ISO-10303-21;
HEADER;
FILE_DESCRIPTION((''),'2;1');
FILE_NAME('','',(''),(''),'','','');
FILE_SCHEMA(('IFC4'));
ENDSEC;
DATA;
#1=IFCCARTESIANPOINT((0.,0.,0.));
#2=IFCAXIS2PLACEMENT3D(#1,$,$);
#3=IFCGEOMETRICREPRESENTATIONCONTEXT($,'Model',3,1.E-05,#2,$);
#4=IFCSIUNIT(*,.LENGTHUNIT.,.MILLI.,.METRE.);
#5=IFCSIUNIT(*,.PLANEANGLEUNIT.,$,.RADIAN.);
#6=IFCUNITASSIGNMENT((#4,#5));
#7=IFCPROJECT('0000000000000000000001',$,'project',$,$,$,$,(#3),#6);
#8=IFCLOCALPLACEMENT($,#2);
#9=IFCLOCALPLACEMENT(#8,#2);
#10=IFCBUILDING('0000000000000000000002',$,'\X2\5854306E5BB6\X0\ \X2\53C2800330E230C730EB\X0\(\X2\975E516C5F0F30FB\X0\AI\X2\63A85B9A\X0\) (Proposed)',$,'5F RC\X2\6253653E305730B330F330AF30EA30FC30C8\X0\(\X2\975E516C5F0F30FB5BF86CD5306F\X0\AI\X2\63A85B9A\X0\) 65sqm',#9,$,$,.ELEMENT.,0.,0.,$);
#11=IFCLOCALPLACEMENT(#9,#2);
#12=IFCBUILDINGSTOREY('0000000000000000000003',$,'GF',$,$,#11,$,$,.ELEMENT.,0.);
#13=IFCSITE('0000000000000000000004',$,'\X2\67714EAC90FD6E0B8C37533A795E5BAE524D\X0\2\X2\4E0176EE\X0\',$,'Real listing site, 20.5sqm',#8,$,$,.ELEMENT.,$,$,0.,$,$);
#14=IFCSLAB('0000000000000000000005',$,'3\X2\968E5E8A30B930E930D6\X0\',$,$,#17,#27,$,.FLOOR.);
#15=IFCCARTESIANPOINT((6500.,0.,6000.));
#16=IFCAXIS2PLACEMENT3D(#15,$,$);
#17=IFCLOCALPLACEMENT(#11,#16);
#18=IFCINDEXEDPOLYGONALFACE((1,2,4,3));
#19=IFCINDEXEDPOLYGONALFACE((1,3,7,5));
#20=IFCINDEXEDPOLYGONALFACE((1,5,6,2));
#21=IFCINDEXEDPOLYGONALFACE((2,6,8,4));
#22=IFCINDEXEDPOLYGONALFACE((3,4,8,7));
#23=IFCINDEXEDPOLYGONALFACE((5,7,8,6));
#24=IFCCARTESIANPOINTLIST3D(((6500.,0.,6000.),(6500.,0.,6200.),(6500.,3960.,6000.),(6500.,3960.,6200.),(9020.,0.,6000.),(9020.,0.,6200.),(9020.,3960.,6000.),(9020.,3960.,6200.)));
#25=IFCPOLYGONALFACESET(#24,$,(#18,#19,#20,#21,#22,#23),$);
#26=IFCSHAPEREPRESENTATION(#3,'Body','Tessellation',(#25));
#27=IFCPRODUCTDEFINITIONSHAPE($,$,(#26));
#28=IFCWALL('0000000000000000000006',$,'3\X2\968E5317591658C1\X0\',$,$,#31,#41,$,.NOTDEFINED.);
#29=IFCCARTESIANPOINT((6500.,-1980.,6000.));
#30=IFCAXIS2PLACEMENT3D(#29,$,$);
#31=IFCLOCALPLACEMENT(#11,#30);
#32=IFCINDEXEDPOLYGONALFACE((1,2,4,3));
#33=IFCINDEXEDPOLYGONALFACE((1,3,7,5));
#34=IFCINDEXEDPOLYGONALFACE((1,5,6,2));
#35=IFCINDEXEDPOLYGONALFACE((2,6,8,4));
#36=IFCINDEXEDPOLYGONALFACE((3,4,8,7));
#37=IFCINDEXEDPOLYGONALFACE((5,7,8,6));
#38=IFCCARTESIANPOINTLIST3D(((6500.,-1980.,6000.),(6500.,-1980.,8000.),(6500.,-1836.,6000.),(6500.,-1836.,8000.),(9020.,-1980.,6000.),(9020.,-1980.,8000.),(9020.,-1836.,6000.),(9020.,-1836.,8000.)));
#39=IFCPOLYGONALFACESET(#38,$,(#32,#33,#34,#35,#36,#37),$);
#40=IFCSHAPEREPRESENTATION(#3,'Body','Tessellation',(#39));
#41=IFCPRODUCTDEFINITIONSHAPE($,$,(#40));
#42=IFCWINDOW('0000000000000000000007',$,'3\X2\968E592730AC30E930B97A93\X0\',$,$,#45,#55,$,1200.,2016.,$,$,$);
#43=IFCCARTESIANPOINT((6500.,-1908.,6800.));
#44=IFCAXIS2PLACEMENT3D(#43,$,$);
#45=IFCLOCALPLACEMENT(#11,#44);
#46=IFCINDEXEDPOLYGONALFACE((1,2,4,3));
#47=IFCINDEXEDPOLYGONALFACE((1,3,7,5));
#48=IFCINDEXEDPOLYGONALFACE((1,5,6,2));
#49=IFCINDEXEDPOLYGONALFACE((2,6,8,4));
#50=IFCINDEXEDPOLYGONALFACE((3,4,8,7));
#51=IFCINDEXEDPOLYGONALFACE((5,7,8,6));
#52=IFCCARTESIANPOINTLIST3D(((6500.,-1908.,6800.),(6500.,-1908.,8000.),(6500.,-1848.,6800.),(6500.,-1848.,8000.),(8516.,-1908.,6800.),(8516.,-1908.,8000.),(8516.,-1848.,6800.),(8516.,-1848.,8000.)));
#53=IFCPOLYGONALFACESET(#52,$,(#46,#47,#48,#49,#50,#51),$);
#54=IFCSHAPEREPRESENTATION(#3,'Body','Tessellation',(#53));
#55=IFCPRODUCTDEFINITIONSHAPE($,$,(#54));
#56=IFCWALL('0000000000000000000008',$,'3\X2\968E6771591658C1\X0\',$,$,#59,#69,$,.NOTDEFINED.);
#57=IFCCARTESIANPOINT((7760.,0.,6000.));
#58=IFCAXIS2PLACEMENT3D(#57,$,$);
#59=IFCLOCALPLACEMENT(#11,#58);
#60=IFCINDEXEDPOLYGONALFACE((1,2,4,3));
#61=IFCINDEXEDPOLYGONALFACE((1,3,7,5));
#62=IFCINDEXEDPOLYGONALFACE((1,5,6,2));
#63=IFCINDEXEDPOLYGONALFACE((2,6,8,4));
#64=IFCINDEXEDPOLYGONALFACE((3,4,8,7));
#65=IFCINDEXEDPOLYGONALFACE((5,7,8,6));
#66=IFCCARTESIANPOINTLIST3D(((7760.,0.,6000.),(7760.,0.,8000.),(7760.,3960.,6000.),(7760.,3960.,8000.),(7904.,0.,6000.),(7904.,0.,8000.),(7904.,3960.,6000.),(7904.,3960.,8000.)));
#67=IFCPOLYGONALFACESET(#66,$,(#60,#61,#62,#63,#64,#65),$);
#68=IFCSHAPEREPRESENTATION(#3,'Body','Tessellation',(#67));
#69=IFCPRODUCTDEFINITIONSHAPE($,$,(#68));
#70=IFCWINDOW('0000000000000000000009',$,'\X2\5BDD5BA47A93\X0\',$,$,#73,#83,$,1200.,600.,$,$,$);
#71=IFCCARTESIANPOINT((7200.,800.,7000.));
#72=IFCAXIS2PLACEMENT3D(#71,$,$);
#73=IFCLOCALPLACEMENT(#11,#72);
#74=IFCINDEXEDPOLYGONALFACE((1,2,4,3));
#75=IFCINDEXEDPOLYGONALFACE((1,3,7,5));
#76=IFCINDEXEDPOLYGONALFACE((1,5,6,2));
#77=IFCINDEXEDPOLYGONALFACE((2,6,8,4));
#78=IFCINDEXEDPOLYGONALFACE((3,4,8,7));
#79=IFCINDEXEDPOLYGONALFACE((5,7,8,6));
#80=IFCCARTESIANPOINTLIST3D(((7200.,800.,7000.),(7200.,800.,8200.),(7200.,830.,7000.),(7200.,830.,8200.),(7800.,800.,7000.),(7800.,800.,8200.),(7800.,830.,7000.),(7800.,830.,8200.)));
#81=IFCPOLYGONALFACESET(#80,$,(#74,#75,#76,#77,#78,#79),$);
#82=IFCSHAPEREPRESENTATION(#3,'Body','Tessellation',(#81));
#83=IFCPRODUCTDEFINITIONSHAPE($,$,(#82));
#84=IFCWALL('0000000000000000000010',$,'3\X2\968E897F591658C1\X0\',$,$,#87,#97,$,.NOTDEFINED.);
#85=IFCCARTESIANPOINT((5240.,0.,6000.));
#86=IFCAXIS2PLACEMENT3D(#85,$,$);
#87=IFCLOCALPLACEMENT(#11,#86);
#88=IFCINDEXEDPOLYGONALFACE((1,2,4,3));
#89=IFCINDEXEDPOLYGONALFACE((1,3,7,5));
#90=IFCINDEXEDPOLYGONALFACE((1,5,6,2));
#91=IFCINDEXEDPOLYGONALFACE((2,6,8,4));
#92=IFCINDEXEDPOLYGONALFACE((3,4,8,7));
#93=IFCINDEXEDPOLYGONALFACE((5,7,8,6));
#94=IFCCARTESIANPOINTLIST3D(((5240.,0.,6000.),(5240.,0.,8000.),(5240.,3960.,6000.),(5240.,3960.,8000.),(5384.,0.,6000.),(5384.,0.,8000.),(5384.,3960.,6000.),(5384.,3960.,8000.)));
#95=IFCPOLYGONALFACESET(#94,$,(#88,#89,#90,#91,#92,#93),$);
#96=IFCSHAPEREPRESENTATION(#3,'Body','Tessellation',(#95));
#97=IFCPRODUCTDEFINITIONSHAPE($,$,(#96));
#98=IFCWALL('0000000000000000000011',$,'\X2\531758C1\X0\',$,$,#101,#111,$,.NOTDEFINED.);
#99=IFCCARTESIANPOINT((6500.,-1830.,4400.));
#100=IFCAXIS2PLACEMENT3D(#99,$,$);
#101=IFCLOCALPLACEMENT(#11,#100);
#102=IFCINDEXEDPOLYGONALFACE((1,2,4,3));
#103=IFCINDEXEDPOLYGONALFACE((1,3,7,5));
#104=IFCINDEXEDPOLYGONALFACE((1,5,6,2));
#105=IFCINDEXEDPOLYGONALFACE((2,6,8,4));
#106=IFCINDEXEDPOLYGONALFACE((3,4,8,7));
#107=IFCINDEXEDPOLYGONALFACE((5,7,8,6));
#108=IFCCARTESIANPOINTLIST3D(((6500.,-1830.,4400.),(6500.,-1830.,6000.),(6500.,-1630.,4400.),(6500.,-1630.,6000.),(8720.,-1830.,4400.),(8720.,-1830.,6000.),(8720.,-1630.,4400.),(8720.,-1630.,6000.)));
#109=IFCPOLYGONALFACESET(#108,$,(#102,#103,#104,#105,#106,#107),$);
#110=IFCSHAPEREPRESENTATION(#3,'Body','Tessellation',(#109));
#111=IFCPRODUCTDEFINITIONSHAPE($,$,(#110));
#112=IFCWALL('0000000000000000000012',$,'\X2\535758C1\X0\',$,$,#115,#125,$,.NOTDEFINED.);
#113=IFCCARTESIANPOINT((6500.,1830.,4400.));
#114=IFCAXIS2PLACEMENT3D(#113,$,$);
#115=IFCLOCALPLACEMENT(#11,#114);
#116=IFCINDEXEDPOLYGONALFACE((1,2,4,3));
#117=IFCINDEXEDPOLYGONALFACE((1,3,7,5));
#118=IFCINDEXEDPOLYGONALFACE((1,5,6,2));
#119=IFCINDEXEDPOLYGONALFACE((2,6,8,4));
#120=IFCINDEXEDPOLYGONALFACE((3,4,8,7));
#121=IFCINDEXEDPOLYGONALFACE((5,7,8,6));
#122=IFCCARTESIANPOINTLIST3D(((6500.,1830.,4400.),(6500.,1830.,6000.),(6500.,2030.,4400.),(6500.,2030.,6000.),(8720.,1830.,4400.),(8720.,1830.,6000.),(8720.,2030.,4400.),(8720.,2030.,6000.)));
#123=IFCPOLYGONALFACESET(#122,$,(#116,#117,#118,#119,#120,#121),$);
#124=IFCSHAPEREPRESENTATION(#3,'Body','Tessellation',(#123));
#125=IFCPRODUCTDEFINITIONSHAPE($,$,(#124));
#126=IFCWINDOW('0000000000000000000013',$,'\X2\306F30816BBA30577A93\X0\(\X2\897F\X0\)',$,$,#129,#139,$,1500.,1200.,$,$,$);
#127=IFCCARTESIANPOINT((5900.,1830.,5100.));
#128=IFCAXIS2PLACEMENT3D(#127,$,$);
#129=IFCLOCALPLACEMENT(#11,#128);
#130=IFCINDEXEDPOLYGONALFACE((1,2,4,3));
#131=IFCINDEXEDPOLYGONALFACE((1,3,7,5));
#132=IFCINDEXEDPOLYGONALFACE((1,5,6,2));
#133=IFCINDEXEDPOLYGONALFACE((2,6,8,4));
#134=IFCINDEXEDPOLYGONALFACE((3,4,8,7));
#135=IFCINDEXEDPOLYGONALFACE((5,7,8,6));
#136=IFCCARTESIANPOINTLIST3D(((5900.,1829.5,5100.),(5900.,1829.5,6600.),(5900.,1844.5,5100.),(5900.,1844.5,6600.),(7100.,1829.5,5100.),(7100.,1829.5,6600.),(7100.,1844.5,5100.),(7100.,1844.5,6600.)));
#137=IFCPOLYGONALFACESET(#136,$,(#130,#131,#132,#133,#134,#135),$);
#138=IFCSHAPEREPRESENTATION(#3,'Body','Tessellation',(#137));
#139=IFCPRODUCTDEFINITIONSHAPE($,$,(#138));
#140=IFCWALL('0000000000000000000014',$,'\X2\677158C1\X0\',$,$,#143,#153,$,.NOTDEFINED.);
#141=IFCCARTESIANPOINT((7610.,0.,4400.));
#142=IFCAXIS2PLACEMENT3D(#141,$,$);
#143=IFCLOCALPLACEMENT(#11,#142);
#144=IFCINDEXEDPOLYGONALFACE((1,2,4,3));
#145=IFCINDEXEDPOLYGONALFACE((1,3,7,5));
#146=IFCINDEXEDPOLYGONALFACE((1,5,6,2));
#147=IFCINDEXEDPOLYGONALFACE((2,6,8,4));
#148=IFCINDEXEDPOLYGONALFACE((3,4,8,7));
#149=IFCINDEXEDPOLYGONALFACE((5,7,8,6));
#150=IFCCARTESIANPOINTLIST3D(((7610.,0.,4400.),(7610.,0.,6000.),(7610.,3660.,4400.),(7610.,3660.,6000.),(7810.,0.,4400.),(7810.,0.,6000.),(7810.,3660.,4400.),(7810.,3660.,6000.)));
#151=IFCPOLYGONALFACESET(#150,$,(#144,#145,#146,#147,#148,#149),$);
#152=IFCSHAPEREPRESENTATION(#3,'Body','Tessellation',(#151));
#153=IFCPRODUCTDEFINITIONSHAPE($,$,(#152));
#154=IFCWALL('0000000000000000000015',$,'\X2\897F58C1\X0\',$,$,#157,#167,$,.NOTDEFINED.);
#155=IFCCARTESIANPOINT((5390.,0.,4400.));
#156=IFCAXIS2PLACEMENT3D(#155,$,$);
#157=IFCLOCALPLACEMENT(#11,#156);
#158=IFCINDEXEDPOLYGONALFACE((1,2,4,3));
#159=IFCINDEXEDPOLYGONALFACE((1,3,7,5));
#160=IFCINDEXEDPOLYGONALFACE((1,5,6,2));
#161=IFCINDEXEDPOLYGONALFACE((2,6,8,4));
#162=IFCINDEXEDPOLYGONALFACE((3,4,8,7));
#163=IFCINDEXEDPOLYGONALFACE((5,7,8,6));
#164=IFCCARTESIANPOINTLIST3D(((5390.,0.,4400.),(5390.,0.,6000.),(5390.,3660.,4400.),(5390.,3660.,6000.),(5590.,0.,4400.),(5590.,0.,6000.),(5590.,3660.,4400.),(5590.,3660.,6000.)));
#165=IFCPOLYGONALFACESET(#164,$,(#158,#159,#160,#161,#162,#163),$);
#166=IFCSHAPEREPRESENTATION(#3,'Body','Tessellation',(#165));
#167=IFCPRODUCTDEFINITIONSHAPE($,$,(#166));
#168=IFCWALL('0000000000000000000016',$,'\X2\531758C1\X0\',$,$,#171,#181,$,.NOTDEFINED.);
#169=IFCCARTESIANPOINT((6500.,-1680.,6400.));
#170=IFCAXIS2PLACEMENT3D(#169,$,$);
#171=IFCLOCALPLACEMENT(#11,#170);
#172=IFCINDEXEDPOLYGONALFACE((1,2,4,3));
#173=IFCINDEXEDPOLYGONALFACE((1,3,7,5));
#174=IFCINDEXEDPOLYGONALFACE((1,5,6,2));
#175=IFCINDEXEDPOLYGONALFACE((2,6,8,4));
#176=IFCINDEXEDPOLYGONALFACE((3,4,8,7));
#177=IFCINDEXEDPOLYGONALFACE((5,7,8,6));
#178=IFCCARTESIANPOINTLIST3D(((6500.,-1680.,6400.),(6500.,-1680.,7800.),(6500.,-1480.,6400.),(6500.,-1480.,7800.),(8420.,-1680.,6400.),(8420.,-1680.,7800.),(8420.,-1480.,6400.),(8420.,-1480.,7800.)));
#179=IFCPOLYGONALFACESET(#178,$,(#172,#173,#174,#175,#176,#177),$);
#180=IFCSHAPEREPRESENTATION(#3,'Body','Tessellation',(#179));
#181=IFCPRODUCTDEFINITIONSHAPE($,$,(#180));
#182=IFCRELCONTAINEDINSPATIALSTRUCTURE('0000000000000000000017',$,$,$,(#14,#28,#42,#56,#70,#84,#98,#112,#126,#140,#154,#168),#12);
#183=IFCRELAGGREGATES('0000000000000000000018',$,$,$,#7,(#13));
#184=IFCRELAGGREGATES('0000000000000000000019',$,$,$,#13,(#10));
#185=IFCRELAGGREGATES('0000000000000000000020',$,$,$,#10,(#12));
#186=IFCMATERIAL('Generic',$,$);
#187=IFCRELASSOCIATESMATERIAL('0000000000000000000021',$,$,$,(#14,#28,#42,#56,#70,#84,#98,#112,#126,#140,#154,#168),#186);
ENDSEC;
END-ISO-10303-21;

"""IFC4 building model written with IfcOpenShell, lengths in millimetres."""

from ifc_helpers import new_model, si_unit, frame, frame_2d, origin, place, context, project, spatial, rectangle, extrude, material, element, fill, save


model = new_model("IFC4")

# Units and contexts
model_context = context("Model", 3, precision=1e-05, world=origin())
ifc_project = project(units=[si_unit("LENGTHUNIT", "METRE", prefix="MILLI"), si_unit("PLANEANGLEUNIT", "RADIAN")], contexts=[model_context])

# Site, building, storey
site_placement = place(None, origin())
site = spatial("IfcSite", under=ifc_project, at=site_placement, Name="東京都渋谷区神宮前2丁目", ObjectType="Real listing site, 20.5sqm", CompositionType="ELEMENT", RefElevation=0.0)
building_placement = place(site_placement, origin())
building = spatial("IfcBuilding", under=site, at=building_placement, Name="塔の家 参考モデル(非公式・AI推定) (Proposed)", ObjectType="5F RC打放しコンクリート(非公式・寸法はAI推定) 65sqm", CompositionType="ELEMENT", ElevationOfRefHeight=0.0, ElevationOfTerrain=0.0)
storey_placement = place(building_placement, origin())
storey = spatial("IfcBuildingStorey", under=building, at=storey_placement, Name="GF", CompositionType="ELEMENT", Elevation=0.0)

# Slab
ifc_material = material(Name="Generic")
slab_placement = place(storey_placement, frame((6500.0, 0.0, 6000.0)))
element("IfcSlab", 1, at=slab_placement, inside=storey, material=ifc_material, Name="3階床スラブ", PredefinedType="FLOOR", context=model_context, shape_type="SweptSolid", body=[
    extrude(rectangle(XDim=2520.0, YDim=3960.0, at=frame_2d((1260.0, 1980.0))), frame((6500.0, 0.0, 6000.0)), (0.0, 0.0, 1.0), 200.0),
])

# Walls, openings, windows
wall_1_placement = place(storey_placement, frame((6500.0, -1980.0, 6000.0)))
wall_1 = element("IfcWall", 2, at=wall_1_placement, inside=storey, material=ifc_material, Name="3階北外壁", PredefinedType="NOTDEFINED", context=model_context, shape_type="SweptSolid", body=[
    extrude(rectangle(XDim=2520.0, YDim=144.0, at=frame_2d((1260.0, 72.0))), frame((6500.0, -1980.0, 6000.0)), (0.0, 0.0, 1.0), 2000.0),
])
opening_1_placement = place(storey_placement, frame((6500.0, -1908.0, 6800.0)))
opening_1 = element("IfcOpeningElement", 3, at=opening_1_placement, cuts=wall_1, PredefinedType="NOTDEFINED", context=model_context, shape_type="SweptSolid", body=[
    extrude(rectangle(XDim=2016.0, YDim=60.0, at=frame_2d((1008.0, 30.0))), frame((6500.0, -1908.0, 6800.0)), (0.0, 0.0, 1.0), 1200.0),
])
window_1_placement = place(storey_placement, frame((6500.0, -1908.0, 6800.0)))
window_1 = element("IfcWindow", 4, at=window_1_placement, inside=storey, material=ifc_material, Name="3階大ガラス窓", OverallHeight=1200.0, OverallWidth=2016.0, context=model_context, shape_type="SweptSolid", body=[
    extrude(rectangle(XDim=2016.0, YDim=60.0, at=frame_2d((1008.0, 30.0))), frame((6500.0, -1908.0, 6800.0)), (0.0, 0.0, 1.0), 1200.0),
])
fill(opening_1, window_1)
wall_2_placement = place(storey_placement, frame((7760.0, 0.0, 6000.0)))
wall_2 = element("IfcWall", 5, at=wall_2_placement, inside=storey, material=ifc_material, Name="3階東外壁", PredefinedType="NOTDEFINED", context=model_context, shape_type="SweptSolid", body=[
    extrude(rectangle(XDim=144.0, YDim=3960.0, at=frame_2d((72.0, 1980.0))), frame((7760.0, 0.0, 6000.0)), (0.0, 0.0, 1.0), 2000.0),
])
opening_2_placement = place(storey_placement, frame((7200.0, 800.0, 7000.0)))
opening_2 = element("IfcOpeningElement", 6, at=opening_2_placement, cuts=wall_2, PredefinedType="NOTDEFINED", context=model_context, shape_type="SweptSolid", body=[
    extrude(rectangle(XDim=600.0, YDim=30.0, at=frame_2d((300.0, 15.0))), frame((7200.0, 800.0, 7000.0)), (0.0, 0.0, 1.0), 1200.0),
])
window_2_placement = place(storey_placement, frame((7200.0, 800.0, 7000.0)))
window_2 = element("IfcWindow", 7, at=window_2_placement, inside=storey, material=ifc_material, Name="寝室窓", OverallHeight=1200.0, OverallWidth=600.0, context=model_context, shape_type="SweptSolid", body=[
    extrude(rectangle(XDim=600.0, YDim=30.0, at=frame_2d((300.0, 15.0))), frame((7200.0, 800.0, 7000.0)), (0.0, 0.0, 1.0), 1200.0),
])
fill(opening_2, window_2)

# Walls
wall_3_placement = place(storey_placement, frame((5240.0, 0.0, 6000.0)))
element("IfcWall", 8, at=wall_3_placement, inside=storey, material=ifc_material, Name="3階西外壁", PredefinedType="NOTDEFINED", context=model_context, shape_type="SweptSolid", body=[
    extrude(rectangle(XDim=144.0, YDim=3960.0, at=frame_2d((72.0, 1980.0))), frame((5240.0, 0.0, 6000.0)), (0.0, 0.0, 1.0), 2000.0),
])
wall_4_placement = place(storey_placement, frame((6500.0, -1830.0, 4400.0)))
element("IfcWall", 9, at=wall_4_placement, inside=storey, material=ifc_material, Name="北壁", PredefinedType="NOTDEFINED", context=model_context, shape_type="SweptSolid", body=[
    extrude(rectangle(XDim=2220.0, YDim=200.0, at=frame_2d((1110.0, 100.0))), frame((6500.0, -1830.0, 4400.0)), (0.0, 0.0, 1.0), 1600.0),
])

# Wall, opening, window
wall_5_placement = place(storey_placement, frame((6500.0, 1830.0, 4400.0)))
wall_5 = element("IfcWall", 10, at=wall_5_placement, inside=storey, material=ifc_material, Name="南壁", PredefinedType="NOTDEFINED", context=model_context, shape_type="SweptSolid", body=[
    extrude(rectangle(XDim=2220.0, YDim=200.0, at=frame_2d((1110.0, 100.0))), frame((6500.0, 1830.0, 4400.0)), (0.0, 0.0, 1.0), 1600.0),
])
opening_3_placement = place(storey_placement, frame((5900.0, 1830.0, 5100.0)))
opening_3 = element("IfcOpeningElement", 11, at=opening_3_placement, cuts=wall_5, PredefinedType="NOTDEFINED", context=model_context, shape_type="SweptSolid", body=[
    extrude(rectangle(XDim=1200.0, YDim=15.0, at=frame_2d((600.0, 7.0))), frame((5900.0, 1830.0, 5100.0)), (0.0, 0.0, 1.0), 1500.0),
])
window_3_placement = place(storey_placement, frame((5900.0, 1830.0, 5100.0)))
window_3 = element("IfcWindow", 12, at=window_3_placement, inside=storey, material=ifc_material, Name="はめ殺し窓(西)", OverallHeight=1500.0, OverallWidth=1200.0, context=model_context, shape_type="SweptSolid", body=[
    extrude(rectangle(XDim=1200.0, YDim=15.0, at=frame_2d((600.0, 7.0))), frame((5900.0, 1830.0, 5100.0)), (0.0, 0.0, 1.0), 1500.0),
])
fill(opening_3, window_3)

# Walls
wall_6_placement = place(storey_placement, frame((7610.0, 0.0, 4400.0)))
element("IfcWall", 13, at=wall_6_placement, inside=storey, material=ifc_material, Name="東壁", PredefinedType="NOTDEFINED", context=model_context, shape_type="SweptSolid", body=[
    extrude(rectangle(XDim=200.0, YDim=3660.0, at=frame_2d((100.0, 1830.0))), frame((7610.0, 0.0, 4400.0)), (0.0, 0.0, 1.0), 1600.0),
])
wall_7_placement = place(storey_placement, frame((5390.0, 0.0, 4400.0)))
element("IfcWall", 14, at=wall_7_placement, inside=storey, material=ifc_material, Name="西壁", PredefinedType="NOTDEFINED", context=model_context, shape_type="SweptSolid", body=[
    extrude(rectangle(XDim=200.0, YDim=3660.0, at=frame_2d((100.0, 1830.0))), frame((5390.0, 0.0, 4400.0)), (0.0, 0.0, 1.0), 1600.0),
])
wall_8_placement = place(storey_placement, frame((6500.0, -1680.0, 6400.0)))
element("IfcWall", 15, at=wall_8_placement, inside=storey, material=ifc_material, Name="北壁", PredefinedType="NOTDEFINED", context=model_context, shape_type="SweptSolid", body=[
    extrude(rectangle(XDim=1920.0, YDim=200.0, at=frame_2d((960.0, 100.0))), frame((6500.0, -1680.0, 6400.0)), (0.0, 0.0, 1.0), 1400.0),
])

save(model, "model.ifc")
